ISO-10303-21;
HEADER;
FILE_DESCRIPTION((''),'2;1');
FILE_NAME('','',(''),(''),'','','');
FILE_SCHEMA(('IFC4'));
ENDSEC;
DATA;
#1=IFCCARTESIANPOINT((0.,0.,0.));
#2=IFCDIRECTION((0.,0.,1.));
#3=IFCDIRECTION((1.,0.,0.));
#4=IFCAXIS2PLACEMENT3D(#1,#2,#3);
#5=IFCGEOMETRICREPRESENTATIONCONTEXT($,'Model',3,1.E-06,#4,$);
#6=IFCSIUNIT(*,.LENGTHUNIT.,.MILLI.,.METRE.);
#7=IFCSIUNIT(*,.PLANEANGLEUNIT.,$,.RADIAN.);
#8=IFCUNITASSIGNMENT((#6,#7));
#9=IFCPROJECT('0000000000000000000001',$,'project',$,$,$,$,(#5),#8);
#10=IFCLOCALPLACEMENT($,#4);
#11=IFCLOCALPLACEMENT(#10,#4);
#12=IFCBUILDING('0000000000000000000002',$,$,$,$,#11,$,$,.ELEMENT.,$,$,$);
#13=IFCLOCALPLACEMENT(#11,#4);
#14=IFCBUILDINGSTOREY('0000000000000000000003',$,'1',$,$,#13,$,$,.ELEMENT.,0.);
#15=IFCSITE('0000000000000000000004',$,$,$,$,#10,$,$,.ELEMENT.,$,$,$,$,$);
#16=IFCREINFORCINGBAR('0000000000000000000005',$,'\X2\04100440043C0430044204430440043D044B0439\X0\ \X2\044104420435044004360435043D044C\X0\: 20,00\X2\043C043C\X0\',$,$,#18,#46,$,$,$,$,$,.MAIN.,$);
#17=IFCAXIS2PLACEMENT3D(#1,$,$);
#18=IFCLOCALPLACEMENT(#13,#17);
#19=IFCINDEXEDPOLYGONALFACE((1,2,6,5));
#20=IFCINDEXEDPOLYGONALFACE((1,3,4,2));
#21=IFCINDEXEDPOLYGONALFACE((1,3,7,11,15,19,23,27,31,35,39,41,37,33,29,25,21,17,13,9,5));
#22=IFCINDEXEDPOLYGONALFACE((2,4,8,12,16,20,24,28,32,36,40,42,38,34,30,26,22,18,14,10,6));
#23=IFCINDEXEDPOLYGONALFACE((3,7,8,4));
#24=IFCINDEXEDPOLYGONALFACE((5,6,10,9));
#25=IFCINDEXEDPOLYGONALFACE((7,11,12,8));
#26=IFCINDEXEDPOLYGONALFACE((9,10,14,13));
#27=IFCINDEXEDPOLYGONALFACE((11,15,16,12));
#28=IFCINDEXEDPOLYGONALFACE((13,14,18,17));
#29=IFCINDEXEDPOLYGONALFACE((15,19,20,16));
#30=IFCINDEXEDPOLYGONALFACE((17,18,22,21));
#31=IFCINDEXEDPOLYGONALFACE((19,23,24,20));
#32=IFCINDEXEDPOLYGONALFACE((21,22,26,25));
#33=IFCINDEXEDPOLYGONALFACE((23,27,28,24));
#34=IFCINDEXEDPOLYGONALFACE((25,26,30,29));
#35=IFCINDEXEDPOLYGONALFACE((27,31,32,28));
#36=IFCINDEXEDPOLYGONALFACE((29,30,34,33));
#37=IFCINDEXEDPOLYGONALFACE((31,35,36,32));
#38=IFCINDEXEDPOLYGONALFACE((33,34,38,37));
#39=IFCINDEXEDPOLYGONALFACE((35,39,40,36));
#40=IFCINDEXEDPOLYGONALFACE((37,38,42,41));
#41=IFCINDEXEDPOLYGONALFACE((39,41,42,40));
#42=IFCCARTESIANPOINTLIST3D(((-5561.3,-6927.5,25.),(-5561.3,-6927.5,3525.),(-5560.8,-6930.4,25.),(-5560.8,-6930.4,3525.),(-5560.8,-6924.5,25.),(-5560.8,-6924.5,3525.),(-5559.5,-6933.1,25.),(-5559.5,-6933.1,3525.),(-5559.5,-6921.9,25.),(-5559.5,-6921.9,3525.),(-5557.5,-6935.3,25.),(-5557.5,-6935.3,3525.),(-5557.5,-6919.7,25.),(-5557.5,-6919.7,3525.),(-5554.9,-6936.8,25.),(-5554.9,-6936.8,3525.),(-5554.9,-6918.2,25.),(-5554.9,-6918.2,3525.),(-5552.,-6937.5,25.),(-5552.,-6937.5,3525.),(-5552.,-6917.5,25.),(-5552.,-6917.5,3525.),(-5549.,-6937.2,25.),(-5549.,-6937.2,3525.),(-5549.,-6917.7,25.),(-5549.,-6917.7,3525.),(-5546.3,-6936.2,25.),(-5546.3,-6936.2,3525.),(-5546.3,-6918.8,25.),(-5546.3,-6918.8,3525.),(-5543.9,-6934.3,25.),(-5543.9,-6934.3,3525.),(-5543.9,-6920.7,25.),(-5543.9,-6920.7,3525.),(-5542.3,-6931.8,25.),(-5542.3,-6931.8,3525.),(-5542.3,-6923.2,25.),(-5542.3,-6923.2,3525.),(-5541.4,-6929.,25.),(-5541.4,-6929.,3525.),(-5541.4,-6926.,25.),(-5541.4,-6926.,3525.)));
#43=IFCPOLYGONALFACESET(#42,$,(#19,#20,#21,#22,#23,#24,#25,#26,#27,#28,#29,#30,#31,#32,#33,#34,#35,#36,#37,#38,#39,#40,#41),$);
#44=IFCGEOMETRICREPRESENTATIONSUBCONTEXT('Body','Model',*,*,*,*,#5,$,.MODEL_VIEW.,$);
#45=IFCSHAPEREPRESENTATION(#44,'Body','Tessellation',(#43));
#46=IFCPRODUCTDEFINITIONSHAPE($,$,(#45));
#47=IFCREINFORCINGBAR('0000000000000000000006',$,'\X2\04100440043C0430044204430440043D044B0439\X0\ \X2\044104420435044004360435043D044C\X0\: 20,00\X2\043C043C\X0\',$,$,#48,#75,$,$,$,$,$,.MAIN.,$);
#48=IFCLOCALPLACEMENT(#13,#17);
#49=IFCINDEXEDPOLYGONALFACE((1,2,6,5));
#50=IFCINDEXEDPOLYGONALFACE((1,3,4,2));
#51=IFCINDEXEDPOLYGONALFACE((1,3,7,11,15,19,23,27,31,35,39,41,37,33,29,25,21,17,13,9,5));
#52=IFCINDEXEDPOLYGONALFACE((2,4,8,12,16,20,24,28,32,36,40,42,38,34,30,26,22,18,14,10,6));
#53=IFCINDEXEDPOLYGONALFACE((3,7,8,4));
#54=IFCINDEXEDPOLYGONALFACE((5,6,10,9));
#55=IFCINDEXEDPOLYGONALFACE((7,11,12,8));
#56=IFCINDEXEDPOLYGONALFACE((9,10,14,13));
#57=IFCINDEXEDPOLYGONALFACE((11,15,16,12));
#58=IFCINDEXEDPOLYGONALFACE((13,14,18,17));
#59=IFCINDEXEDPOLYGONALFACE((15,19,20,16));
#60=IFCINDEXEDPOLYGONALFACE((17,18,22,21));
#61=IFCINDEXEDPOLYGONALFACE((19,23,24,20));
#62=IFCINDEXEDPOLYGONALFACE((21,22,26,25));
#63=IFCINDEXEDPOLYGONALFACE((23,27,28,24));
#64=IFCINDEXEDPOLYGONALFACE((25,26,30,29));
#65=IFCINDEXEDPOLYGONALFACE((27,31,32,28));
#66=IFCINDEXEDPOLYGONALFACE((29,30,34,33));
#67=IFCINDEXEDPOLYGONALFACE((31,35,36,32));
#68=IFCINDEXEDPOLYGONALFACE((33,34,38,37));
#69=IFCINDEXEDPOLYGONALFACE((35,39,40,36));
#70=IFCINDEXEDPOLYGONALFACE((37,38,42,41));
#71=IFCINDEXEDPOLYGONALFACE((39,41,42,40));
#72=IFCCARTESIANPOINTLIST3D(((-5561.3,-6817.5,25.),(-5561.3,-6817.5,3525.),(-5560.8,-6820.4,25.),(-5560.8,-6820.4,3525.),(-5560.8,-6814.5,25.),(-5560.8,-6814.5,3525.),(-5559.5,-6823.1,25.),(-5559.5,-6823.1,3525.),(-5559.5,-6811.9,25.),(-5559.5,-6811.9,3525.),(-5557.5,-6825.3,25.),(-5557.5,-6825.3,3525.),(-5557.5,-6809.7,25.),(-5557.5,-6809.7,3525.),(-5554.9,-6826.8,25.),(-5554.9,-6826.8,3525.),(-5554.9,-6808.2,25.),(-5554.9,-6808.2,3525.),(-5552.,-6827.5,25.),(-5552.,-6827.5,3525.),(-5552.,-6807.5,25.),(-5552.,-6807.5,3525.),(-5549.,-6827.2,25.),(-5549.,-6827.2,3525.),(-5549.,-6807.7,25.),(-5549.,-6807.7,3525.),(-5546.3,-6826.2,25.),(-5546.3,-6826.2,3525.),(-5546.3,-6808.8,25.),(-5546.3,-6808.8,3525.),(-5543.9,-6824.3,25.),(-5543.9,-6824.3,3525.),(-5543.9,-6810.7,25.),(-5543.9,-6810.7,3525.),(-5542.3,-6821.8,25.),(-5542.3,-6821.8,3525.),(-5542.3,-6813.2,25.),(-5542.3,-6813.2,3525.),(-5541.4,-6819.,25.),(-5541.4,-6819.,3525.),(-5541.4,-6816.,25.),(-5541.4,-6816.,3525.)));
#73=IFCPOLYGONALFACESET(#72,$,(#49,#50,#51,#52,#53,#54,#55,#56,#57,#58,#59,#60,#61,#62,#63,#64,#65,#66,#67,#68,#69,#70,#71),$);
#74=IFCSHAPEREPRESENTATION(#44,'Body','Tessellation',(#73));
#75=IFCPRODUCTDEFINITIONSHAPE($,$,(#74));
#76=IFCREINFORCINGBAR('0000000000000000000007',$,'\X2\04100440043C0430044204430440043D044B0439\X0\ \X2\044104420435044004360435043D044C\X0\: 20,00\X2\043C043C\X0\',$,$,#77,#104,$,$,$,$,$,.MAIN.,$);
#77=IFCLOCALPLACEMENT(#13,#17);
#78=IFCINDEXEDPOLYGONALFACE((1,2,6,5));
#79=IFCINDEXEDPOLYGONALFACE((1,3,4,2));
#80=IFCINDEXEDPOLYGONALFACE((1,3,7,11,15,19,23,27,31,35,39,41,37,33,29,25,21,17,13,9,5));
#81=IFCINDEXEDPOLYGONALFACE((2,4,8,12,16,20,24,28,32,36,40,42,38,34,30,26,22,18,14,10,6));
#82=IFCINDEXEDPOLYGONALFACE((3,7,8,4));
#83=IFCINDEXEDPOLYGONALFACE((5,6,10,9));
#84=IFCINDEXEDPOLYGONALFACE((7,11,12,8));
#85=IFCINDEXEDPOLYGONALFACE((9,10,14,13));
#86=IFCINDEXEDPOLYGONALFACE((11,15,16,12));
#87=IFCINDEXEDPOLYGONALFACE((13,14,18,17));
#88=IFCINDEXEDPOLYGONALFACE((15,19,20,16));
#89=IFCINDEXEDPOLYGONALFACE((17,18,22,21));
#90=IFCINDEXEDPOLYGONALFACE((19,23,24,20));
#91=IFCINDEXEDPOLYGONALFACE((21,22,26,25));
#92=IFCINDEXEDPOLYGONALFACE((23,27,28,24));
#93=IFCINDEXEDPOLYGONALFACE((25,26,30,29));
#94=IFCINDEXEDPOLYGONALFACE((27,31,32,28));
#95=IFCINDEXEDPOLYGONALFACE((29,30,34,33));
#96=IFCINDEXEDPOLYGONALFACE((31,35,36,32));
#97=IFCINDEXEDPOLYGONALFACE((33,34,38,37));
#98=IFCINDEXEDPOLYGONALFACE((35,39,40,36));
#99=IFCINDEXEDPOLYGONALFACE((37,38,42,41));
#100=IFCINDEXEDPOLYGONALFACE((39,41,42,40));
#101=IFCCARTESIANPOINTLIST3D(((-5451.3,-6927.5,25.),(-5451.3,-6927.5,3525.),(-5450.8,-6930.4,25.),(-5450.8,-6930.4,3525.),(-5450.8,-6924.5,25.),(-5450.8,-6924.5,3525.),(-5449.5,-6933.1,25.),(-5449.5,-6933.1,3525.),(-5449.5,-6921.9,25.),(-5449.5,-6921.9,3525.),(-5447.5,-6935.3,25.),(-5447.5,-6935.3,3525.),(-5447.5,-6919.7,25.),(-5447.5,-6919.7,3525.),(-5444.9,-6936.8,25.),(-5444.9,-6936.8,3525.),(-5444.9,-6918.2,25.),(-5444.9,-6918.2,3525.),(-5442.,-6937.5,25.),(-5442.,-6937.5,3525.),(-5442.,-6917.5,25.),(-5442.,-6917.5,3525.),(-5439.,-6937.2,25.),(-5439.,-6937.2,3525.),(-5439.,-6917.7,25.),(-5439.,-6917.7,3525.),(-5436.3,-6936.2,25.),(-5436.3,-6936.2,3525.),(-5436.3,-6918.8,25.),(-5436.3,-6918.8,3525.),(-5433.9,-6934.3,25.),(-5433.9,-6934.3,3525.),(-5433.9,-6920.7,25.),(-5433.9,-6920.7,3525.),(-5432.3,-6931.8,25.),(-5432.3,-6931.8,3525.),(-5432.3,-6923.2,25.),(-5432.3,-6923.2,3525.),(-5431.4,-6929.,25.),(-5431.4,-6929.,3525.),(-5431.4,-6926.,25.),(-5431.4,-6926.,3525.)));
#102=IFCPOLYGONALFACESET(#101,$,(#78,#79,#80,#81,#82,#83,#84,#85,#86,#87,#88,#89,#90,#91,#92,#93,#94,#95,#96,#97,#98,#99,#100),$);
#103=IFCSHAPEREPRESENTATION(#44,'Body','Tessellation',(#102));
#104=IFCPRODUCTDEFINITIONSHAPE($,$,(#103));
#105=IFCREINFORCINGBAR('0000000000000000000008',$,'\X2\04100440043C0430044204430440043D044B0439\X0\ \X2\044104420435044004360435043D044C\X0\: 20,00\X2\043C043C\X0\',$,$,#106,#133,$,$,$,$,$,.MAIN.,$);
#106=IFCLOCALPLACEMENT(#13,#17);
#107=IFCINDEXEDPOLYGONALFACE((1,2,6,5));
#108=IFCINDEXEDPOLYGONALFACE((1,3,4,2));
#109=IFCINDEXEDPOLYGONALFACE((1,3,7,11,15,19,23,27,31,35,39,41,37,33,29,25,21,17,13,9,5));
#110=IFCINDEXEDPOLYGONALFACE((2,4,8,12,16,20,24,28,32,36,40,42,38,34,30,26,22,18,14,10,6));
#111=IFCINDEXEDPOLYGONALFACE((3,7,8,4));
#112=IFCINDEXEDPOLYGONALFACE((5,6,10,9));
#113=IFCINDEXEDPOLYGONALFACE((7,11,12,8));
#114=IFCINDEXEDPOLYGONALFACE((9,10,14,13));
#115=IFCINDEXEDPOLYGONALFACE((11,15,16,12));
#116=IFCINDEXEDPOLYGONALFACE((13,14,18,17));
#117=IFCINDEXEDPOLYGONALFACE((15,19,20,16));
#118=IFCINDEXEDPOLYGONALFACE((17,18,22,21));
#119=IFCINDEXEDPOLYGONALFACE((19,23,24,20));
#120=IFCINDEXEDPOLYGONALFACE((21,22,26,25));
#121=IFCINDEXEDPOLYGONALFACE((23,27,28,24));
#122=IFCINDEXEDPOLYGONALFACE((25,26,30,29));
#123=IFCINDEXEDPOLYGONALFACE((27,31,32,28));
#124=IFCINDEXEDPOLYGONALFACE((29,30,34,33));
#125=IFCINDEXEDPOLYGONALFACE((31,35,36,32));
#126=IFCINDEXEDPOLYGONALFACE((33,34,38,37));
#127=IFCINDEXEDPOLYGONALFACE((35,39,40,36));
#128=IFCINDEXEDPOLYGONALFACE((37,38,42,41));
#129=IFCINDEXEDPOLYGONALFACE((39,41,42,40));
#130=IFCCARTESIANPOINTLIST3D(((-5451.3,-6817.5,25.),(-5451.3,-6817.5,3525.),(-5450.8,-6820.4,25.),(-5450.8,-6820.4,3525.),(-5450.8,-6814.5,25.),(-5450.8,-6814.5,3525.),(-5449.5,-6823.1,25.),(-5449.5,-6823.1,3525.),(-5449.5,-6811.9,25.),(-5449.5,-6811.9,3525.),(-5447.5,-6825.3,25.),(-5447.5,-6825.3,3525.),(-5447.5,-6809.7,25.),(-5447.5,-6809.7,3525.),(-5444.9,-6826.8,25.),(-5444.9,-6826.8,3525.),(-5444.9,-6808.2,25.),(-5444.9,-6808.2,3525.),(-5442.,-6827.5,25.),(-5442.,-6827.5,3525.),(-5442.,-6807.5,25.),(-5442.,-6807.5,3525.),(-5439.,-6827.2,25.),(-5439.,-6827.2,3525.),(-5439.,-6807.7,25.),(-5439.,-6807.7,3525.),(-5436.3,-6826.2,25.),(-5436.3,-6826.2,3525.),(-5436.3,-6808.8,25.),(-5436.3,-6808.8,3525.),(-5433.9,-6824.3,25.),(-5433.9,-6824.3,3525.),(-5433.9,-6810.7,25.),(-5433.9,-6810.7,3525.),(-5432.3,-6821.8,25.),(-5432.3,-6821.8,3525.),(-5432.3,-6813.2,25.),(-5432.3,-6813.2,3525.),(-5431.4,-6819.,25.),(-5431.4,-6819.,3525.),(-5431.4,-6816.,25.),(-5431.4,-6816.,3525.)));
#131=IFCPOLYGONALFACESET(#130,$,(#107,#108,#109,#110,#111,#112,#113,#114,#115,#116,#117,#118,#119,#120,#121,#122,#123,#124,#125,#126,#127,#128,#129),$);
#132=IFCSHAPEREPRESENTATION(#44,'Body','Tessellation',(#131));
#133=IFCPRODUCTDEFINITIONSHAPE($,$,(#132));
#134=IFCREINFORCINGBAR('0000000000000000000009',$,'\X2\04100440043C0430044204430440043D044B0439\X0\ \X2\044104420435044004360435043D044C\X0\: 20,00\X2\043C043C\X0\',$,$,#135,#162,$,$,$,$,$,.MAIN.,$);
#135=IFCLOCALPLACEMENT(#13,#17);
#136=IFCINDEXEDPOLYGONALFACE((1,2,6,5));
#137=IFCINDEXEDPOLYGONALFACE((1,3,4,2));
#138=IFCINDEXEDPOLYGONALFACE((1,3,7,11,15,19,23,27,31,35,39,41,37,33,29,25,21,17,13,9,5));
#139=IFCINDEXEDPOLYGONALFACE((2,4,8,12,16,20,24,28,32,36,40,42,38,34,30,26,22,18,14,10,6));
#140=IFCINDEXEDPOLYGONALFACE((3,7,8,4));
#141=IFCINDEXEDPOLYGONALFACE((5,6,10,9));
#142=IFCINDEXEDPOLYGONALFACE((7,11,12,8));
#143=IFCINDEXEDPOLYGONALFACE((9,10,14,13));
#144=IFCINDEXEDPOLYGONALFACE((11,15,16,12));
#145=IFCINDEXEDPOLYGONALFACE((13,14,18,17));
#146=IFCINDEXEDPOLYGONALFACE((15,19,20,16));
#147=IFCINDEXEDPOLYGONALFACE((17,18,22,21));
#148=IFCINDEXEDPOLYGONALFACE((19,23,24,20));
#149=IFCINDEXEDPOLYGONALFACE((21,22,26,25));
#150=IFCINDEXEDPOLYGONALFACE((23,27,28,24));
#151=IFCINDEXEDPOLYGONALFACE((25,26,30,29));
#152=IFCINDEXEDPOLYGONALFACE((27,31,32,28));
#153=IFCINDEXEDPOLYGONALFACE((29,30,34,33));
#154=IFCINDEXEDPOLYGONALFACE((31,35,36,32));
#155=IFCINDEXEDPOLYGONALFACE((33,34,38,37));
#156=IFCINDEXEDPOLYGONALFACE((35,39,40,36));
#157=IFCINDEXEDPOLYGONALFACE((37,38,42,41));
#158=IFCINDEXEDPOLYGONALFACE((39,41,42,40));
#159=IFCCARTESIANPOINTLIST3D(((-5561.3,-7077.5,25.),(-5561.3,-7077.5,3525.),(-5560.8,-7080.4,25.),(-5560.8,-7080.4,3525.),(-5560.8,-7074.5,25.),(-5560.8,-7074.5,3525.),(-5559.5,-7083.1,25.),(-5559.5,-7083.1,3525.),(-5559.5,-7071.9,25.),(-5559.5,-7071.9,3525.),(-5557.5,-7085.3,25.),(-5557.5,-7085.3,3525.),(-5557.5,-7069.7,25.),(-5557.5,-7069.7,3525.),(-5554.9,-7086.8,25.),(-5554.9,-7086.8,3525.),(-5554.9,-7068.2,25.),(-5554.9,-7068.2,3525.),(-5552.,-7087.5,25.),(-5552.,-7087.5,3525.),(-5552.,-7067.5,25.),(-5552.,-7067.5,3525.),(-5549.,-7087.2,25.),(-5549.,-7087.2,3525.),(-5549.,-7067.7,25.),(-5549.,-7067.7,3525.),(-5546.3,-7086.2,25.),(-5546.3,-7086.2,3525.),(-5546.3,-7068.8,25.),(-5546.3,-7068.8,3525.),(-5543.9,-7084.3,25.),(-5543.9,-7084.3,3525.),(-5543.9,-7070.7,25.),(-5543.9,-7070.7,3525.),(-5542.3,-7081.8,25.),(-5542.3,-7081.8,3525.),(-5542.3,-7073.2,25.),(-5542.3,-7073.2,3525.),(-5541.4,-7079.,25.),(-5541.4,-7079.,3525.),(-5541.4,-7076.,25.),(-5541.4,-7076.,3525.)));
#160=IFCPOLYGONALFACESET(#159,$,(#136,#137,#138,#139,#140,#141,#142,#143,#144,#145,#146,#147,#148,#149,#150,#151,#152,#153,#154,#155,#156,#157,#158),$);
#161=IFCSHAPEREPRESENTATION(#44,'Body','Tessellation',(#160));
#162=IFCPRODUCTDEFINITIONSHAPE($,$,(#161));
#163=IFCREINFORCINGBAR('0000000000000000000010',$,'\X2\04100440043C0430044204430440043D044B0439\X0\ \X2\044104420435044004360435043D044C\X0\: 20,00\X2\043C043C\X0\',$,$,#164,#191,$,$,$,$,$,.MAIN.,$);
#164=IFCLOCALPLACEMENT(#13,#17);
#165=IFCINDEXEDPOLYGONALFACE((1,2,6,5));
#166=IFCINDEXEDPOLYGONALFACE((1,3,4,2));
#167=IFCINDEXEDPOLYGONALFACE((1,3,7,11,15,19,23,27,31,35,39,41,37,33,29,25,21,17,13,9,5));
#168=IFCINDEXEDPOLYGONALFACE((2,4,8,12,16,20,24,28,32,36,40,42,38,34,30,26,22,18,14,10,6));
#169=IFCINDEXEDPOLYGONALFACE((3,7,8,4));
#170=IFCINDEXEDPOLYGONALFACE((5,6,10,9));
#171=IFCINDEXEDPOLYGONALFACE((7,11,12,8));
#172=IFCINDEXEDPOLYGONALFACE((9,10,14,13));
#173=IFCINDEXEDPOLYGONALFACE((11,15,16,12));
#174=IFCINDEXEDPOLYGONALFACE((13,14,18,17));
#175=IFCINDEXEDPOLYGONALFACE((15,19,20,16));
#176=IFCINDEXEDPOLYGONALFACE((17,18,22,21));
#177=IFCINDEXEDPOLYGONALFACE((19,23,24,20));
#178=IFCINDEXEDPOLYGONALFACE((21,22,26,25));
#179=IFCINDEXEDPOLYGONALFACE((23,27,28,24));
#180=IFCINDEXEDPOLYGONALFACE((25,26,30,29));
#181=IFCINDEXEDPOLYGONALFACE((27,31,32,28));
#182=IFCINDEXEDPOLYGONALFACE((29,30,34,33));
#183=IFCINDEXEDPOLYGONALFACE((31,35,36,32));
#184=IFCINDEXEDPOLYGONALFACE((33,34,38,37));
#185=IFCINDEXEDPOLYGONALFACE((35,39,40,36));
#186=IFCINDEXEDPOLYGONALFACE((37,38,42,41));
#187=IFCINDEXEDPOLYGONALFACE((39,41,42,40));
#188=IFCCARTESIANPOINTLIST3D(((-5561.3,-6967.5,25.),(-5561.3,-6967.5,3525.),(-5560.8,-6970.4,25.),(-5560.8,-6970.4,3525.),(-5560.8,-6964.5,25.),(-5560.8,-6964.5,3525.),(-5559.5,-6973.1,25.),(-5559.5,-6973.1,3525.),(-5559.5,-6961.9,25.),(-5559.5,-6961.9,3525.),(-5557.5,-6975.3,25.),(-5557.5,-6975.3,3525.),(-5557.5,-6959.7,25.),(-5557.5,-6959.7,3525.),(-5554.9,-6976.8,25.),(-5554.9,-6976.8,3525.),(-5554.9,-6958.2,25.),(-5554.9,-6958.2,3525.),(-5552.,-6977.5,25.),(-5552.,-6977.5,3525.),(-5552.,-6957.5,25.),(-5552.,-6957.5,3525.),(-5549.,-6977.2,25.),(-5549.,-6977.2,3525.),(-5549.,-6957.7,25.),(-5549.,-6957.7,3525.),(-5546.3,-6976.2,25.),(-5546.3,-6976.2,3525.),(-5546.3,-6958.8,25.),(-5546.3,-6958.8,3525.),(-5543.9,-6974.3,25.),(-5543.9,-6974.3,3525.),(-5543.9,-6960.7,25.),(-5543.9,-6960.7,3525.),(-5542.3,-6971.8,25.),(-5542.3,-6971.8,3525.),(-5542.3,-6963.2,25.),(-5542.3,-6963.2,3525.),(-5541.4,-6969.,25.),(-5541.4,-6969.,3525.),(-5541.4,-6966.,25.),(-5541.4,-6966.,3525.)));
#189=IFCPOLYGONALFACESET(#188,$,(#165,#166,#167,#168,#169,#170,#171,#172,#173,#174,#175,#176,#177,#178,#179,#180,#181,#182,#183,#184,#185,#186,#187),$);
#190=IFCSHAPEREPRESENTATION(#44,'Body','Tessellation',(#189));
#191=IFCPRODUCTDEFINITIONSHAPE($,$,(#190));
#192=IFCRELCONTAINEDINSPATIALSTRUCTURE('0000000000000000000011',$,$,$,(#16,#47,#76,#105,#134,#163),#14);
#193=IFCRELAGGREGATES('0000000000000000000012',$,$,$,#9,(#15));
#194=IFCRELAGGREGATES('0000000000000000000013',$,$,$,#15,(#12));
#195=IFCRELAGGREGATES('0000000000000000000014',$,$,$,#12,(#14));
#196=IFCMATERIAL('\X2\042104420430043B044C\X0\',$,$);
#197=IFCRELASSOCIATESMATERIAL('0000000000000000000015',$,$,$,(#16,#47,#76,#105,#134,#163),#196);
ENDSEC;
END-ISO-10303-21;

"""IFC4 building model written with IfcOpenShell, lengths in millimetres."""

from ifc_helpers import new_model, entity, si_unit, origin_with_axes, place, context, subcontext, project, spatial, source, transform, mapped, material, element, save


model = new_model("IFC4")

# Units and contexts
model_context = context("Model", 3, precision=1e-06, world=origin_with_axes())
body_context = subcontext(model_context, "Body", "Model", "MODEL_VIEW")
ifc_project = project(units=[si_unit("LENGTHUNIT", "METRE", prefix="MILLI"), si_unit("PLANEANGLEUNIT", "RADIAN")], contexts=[model_context])

# Site, building, storey
site_placement = place(None, origin_with_axes())
site = spatial("IfcSite", under=ifc_project, at=site_placement, CompositionType="ELEMENT")
building_placement = place(site_placement, origin_with_axes())
building = spatial("IfcBuilding", under=site, at=building_placement, CompositionType="ELEMENT")
storey_placement = place(building_placement, origin_with_axes())
storey = spatial("IfcBuildingStorey", under=building, at=storey_placement, Name="1", CompositionType="ELEMENT", Elevation=0.0)

# Reinforcing bars
ifc_material = material(Name="Сталь")
shared_shape_1 = source(origin_with_axes(), body_context, "Body", "AdvancedSweptSolid", [
    entity("IfcSweptDiskSolid", entity("IfcIndexedPolyCurve", entity("IfcCartesianPointList3D", [[0.0, 0.0, 0.0], [3500.0, 0.0, 0.0]]), [entity("IfcLineIndex", [1, 2])]), 10.0),
])
reinforcing_bar_1_placement = place(storey_placement, origin_with_axes())
element("IfcReinforcingBar", 1, at=reinforcing_bar_1_placement, inside=storey, material=ifc_material, Name="Арматурный стержень: 20,00мм", PredefinedType="MAIN", context=body_context, shape_type="MappedRepresentation", body=[
    mapped(shared_shape_1, transform((-5551.3, -6927.5, 25.0), x_axis=(0.0, 0.0, 1.0), y_axis=(0.0, 1.0, 0.0), z_axis=(-1.0, 0.0, 0.0), scale=1.0)),
])
reinforcing_bar_2_placement = place(storey_placement, origin_with_axes())
element("IfcReinforcingBar", 2, at=reinforcing_bar_2_placement, inside=storey, material=ifc_material, Name="Арматурный стержень: 20,00мм", PredefinedType="MAIN", context=body_context, shape_type="MappedRepresentation", body=[
    mapped(shared_shape_1, transform((-5551.3, -6817.5, 25.0), x_axis=(0.0, 0.0, 1.0), y_axis=(0.0, 1.0, 0.0), z_axis=(-1.0, 0.0, 0.0), scale=1.0)),
])
reinforcing_bar_3_placement = place(storey_placement, origin_with_axes())
element("IfcReinforcingBar", 3, at=reinforcing_bar_3_placement, inside=storey, material=ifc_material, Name="Арматурный стержень: 20,00мм", PredefinedType="MAIN", context=body_context, shape_type="MappedRepresentation", body=[
    mapped(shared_shape_1, transform((-5441.3, -6927.5, 25.0), x_axis=(0.0, 0.0, 1.0), y_axis=(0.0, 1.0, 0.0), z_axis=(-1.0, 0.0, 0.0), scale=1.0)),
])
reinforcing_bar_4_placement = place(storey_placement, origin_with_axes())
element("IfcReinforcingBar", 4, at=reinforcing_bar_4_placement, inside=storey, material=ifc_material, Name="Арматурный стержень: 20,00мм", PredefinedType="MAIN", context=body_context, shape_type="MappedRepresentation", body=[
    mapped(shared_shape_1, transform((-5441.3, -6817.5, 25.0), x_axis=(0.0, 0.0, 1.0), y_axis=(0.0, 1.0, 0.0), z_axis=(-1.0, 0.0, 0.0), scale=1.0)),
])
reinforcing_bar_5_placement = place(storey_placement, origin_with_axes())
element("IfcReinforcingBar", 5, at=reinforcing_bar_5_placement, inside=storey, material=ifc_material, Name="Арматурный стержень: 20,00мм", PredefinedType="MAIN", context=body_context, shape_type="MappedRepresentation", body=[
    mapped(shared_shape_1, transform((-5551.3, -7077.5, 25.0), x_axis=(0.0, 0.0, 1.0), y_axis=(0.0, 1.0, 0.0), z_axis=(-1.0, 0.0, 0.0), scale=1.0)),
])
reinforcing_bar_6_placement = place(storey_placement, origin_with_axes())
element("IfcReinforcingBar", 6, at=reinforcing_bar_6_placement, inside=storey, material=ifc_material, Name="Арматурный стержень: 20,00мм", PredefinedType="MAIN", context=body_context, shape_type="MappedRepresentation", body=[
    mapped(shared_shape_1, transform((-5551.3, -6967.5, 25.0), x_axis=(0.0, 0.0, 1.0), y_axis=(0.0, 1.0, 0.0), z_axis=(-1.0, 0.0, 0.0), scale=1.0)),
])

save(model, "model.ifc")
